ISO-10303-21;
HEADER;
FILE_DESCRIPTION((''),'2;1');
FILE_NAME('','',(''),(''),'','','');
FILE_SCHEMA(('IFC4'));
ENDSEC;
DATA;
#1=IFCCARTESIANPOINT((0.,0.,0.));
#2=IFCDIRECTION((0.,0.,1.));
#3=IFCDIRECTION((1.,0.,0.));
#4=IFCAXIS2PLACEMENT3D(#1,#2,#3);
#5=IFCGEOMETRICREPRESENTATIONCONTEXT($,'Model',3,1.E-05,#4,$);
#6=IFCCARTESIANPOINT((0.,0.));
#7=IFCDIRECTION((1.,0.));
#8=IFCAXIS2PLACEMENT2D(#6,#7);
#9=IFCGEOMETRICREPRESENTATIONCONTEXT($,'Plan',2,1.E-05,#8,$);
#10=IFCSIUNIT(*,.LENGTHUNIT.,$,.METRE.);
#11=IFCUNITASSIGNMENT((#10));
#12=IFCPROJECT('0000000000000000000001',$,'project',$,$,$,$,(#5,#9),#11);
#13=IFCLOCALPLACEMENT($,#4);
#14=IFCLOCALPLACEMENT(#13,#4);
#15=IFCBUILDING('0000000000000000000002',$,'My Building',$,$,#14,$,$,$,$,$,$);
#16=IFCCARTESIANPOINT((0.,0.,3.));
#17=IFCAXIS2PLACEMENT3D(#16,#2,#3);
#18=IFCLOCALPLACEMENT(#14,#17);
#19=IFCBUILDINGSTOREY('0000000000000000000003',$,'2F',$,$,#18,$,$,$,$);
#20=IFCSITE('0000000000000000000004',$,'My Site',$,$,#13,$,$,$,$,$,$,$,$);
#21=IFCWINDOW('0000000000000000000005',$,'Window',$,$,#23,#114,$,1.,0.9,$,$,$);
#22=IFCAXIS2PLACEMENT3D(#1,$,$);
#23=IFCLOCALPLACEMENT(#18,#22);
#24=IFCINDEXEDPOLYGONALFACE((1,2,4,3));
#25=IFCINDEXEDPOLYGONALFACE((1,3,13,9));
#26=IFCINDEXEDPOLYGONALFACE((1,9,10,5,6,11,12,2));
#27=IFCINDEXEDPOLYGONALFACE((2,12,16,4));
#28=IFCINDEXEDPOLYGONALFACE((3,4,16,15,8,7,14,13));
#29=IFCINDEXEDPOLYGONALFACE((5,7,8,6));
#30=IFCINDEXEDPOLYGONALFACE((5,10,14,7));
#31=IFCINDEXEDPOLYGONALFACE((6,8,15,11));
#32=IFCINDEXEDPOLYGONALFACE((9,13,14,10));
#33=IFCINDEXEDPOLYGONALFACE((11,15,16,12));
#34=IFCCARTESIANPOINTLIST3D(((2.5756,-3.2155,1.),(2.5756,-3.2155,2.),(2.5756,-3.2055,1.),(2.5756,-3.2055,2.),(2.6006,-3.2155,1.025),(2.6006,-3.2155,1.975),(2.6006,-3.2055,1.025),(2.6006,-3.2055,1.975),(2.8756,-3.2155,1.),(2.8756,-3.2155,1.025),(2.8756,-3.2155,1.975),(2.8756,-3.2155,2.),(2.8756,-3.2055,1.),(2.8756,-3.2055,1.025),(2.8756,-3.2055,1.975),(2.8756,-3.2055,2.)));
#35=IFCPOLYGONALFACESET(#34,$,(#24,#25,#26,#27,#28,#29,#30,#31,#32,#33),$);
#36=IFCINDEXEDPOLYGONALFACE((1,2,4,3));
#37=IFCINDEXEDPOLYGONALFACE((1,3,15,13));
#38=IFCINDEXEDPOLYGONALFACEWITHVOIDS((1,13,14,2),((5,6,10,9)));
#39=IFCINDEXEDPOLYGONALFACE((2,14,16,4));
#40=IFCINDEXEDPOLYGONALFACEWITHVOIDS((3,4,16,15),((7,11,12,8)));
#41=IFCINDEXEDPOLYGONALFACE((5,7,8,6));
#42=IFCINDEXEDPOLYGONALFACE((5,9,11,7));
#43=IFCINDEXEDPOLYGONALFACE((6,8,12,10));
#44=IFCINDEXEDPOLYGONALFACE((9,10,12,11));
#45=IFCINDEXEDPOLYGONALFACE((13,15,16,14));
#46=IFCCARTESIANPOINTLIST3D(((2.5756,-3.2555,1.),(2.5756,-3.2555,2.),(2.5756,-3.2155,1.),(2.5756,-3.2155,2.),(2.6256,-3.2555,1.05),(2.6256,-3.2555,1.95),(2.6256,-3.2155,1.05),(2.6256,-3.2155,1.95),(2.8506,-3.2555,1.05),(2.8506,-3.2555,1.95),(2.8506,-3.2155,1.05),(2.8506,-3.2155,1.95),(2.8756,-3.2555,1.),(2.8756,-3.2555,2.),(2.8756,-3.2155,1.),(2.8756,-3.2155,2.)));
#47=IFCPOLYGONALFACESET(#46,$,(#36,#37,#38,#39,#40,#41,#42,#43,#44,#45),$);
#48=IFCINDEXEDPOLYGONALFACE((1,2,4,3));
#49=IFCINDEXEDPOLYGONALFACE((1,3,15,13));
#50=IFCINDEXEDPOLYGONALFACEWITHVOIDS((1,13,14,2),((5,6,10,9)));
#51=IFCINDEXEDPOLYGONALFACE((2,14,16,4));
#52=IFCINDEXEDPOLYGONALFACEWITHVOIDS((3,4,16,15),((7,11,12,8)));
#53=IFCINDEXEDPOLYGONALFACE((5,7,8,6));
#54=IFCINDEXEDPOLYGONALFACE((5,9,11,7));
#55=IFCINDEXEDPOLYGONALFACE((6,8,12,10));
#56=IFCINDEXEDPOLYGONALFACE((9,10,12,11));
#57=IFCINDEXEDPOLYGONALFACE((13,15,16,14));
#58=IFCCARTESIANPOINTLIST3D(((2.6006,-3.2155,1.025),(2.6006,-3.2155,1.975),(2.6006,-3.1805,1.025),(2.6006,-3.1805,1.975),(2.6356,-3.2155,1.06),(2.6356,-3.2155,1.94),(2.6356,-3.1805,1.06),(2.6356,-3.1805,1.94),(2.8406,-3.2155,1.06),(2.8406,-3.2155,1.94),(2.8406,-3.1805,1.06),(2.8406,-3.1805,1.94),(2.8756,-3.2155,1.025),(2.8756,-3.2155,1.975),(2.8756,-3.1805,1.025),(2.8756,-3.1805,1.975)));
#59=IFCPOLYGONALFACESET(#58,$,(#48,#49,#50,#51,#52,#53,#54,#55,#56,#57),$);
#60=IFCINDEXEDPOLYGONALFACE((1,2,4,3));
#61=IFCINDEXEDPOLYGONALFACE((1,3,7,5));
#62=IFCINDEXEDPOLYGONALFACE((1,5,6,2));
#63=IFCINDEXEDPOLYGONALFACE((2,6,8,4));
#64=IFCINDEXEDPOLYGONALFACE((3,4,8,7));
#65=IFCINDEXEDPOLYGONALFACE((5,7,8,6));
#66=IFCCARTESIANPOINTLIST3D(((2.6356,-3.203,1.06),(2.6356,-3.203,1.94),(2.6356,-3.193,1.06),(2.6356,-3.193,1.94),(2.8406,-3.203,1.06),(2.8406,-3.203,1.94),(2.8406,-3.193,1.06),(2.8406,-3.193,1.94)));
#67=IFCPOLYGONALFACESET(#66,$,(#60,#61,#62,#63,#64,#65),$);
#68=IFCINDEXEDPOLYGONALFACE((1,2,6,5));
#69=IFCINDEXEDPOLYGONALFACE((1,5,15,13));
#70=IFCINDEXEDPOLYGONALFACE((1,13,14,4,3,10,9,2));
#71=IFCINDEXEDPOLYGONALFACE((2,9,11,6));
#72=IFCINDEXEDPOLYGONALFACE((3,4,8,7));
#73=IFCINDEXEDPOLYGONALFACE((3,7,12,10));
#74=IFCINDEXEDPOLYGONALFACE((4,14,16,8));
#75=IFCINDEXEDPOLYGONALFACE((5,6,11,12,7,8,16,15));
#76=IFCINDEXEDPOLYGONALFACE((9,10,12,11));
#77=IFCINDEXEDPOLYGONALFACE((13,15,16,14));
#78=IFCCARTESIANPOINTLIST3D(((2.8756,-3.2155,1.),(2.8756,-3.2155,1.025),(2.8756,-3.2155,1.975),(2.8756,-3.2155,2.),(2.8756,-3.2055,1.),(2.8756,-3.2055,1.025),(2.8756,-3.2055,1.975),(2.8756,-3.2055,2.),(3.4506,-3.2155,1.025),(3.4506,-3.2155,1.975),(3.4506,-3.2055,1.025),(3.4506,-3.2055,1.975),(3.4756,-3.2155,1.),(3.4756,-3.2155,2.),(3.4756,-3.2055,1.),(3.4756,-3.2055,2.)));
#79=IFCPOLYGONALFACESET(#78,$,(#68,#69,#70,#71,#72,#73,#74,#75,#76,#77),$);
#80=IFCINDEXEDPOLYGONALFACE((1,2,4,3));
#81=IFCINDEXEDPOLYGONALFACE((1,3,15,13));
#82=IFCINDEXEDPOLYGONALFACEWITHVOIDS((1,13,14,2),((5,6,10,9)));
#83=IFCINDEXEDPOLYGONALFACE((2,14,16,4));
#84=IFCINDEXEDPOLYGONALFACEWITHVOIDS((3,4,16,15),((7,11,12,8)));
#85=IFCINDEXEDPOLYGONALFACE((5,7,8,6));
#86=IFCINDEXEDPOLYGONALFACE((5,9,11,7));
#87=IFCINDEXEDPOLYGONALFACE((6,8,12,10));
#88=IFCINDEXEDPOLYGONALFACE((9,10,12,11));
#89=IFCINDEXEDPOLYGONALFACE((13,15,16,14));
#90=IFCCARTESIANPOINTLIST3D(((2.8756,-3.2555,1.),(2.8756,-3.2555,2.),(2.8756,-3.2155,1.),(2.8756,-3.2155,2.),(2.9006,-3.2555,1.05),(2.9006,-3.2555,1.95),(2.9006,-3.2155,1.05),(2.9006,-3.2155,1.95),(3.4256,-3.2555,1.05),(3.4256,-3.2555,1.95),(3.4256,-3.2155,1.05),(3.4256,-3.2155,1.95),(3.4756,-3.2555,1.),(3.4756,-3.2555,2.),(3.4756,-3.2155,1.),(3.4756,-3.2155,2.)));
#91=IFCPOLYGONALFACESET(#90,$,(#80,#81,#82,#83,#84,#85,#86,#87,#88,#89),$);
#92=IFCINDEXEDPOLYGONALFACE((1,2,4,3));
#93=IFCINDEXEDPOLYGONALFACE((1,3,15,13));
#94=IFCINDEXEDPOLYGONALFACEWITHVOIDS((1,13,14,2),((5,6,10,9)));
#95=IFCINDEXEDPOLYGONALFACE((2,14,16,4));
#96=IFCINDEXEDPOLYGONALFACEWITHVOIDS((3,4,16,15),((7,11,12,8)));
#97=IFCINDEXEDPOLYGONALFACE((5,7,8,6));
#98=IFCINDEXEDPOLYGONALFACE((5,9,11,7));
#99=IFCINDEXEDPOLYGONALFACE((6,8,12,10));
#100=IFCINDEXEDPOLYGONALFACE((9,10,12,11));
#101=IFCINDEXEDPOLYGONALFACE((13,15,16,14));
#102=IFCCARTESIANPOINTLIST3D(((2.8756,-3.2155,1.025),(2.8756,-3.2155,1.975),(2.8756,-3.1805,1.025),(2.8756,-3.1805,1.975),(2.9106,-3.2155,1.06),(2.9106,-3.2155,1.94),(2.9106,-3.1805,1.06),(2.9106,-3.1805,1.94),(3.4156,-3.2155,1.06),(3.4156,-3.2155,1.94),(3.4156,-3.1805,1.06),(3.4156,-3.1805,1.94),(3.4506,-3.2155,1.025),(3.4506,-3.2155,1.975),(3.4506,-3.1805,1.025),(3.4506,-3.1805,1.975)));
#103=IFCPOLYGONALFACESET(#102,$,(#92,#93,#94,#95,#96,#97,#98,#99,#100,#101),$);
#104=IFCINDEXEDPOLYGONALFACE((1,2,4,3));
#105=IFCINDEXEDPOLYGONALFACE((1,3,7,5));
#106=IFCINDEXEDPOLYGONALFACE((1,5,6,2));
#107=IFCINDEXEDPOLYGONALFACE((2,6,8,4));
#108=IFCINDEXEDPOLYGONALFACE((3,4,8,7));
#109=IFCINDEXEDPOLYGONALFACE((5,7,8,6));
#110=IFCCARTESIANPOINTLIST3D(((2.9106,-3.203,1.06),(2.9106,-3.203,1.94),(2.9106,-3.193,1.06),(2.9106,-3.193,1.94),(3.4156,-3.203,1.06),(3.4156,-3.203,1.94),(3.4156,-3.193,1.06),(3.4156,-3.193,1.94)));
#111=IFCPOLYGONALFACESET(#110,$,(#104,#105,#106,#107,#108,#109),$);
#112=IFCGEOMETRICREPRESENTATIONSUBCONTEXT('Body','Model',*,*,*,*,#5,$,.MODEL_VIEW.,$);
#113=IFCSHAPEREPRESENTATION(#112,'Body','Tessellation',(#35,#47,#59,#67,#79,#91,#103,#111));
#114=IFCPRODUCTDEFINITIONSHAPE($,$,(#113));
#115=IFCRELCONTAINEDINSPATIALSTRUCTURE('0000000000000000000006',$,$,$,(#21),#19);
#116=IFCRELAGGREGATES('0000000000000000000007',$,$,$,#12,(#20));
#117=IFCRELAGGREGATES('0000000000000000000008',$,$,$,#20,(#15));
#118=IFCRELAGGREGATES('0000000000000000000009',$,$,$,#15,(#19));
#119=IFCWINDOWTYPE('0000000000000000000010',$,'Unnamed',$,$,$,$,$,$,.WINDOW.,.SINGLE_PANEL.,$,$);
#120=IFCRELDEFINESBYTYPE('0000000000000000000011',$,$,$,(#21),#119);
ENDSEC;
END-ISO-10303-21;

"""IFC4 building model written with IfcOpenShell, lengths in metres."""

from ifc_helpers import new_model, entity, si_unit, frame, origin_with_axes, origin_2d_with_axis, place, context, subcontext, project, spatial, line, indexed_curve, outline, extrude, shape, source, transform, mapped, type_object, type_shapes, element, save


model = new_model("IFC4")

# Units and contexts
model_context = context("Model", 3, precision=1e-05, world=origin_with_axes())
plan_context = context("Plan", 2, precision=1e-05, world=origin_2d_with_axis())
body_context_1 = subcontext(model_context, "Body", "Model", "MODEL_VIEW")
body_context_2 = subcontext(plan_context, "Body", "Plan", "PLAN_VIEW")
ifc_project = project(units=[si_unit("LENGTHUNIT", "METRE")], contexts=[model_context, plan_context])

# Site, building, storey
site_placement = place(None, origin_with_axes())
site = spatial("IfcSite", under=ifc_project, at=site_placement, Name="My Site")
building_placement = place(site_placement, origin_with_axes())
building = spatial("IfcBuilding", under=site, at=building_placement, Name="My Building")
storey_placement = place(building_placement, frame((0.0, 0.0, 3.0), z_axis=(0.0, 0.0, 1.0), x_axis=(1.0, 0.0, 0.0)))
storey = spatial("IfcBuildingStorey", under=building, at=storey_placement, Name="2F")

# Window
window_type = type_object("IfcWindowType", Name="Unnamed", PartitioningType="SINGLE_PANEL", PredefinedType="WINDOW")
shared_shape_1 = source(origin_with_axes(), body_context_1, "Body", "SweptSolid", [
    extrude(outline(indexed_curve([(0.3, 0.0), (0.0, 0.0), (0.0, 1.0), (0.3, 1.0), (0.3, 0.975), (0.025, 0.975), (0.025, 0.025), (0.3, 0.025)], segments=[line(1, 2, 3, 4, 5, 6, 7, 8, 1)])), frame((0.0, 0.09, 0.0), z_axis=(0.0, -1.0, 0.0), x_axis=(1.0, 0.0, 0.0)), (0.0, 0.0, -1.0), 0.01),
    extrude(outline(indexed_curve([(0.0, 0.0), (0.3, 0.0), (0.3, 1.0), (0.0, 1.0)], segments=[line(1, 2, 3, 4, 1)]), holes=[indexed_curve([(0.05, 0.05), (0.275, 0.05), (0.275, 0.95), (0.05, 0.95)], segments=[line(1, 2, 3, 4, 1)])]), frame((0.0, 0.05, 0.0), z_axis=(0.0, -1.0, 0.0), x_axis=(1.0, 0.0, 0.0)), (0.0, 0.0, -1.0), 0.04),
    extrude(outline(indexed_curve([(0.0, 0.0), (0.275, 0.0), (0.275, 0.95), (0.0, 0.95)], segments=[line(1, 2, 3, 4, 1)]), holes=[indexed_curve([(0.035, 0.035), (0.24, 0.035), (0.24, 0.915), (0.035, 0.915)], segments=[line(1, 2, 3, 4, 1)])]), frame((0.025, 0.09, 0.025), z_axis=(0.0, -1.0, 0.0), x_axis=(1.0, 0.0, 0.0)), (0.0, 0.0, -1.0), 0.035),
    extrude(outline(indexed_curve([(0.035, 0.035), (0.24, 0.035), (0.24, 0.915), (0.035, 0.915)], segments=[line(1, 2, 3, 4, 1)])), frame((0.025, 0.1025, 0.025), z_axis=(0.0, -1.0, 0.0), x_axis=(1.0, 0.0, 0.0)), (0.0, 0.0, -1.0), 0.01),
    extrude(outline(indexed_curve([(0.0, 1.0), (0.6, 1.0), (0.6, 0.0), (0.0, 0.0), (0.0, 0.025), (0.575, 0.025), (0.575, 0.975), (0.0, 0.975)], segments=[line(1, 2, 3, 4, 5, 6, 7, 8, 1)])), frame((0.3, 0.09, 0.0), z_axis=(0.0, -1.0, 0.0), x_axis=(1.0, 0.0, 0.0)), (0.0, 0.0, -1.0), 0.01),
    extrude(outline(indexed_curve([(0.0, 0.0), (0.6, 0.0), (0.6, 1.0), (0.0, 1.0)], segments=[line(1, 2, 3, 4, 1)]), holes=[indexed_curve([(0.025, 0.05), (0.55, 0.05), (0.55, 0.95), (0.025, 0.95)], segments=[line(1, 2, 3, 4, 1)])]), frame((0.3, 0.05, 0.0), z_axis=(0.0, -1.0, 0.0), x_axis=(1.0, 0.0, 0.0)), (0.0, 0.0, -1.0), 0.04),
    extrude(outline(indexed_curve([(0.0, 0.0), (0.575, 0.0), (0.575, 0.95), (0.0, 0.95)], segments=[line(1, 2, 3, 4, 1)]), holes=[indexed_curve([(0.035, 0.035), (0.54, 0.035), (0.54, 0.915), (0.035, 0.915)], segments=[line(1, 2, 3, 4, 1)])]), frame((0.3, 0.09, 0.025), z_axis=(0.0, -1.0, 0.0), x_axis=(1.0, 0.0, 0.0)), (0.0, 0.0, -1.0), 0.035),
    extrude(outline(indexed_curve([(0.035, 0.035), (0.54, 0.035), (0.54, 0.915), (0.035, 0.915)], segments=[line(1, 2, 3, 4, 1)])), frame((0.3, 0.1025, 0.025), z_axis=(0.0, -1.0, 0.0), x_axis=(1.0, 0.0, 0.0)), (0.0, 0.0, -1.0), 0.01),
])
shared_shape_2 = source(origin_with_axes(), body_context_2, "Body", "Curve2D", [
    entity("IfcIndexedPolyCurve", entity("IfcCartesianPointList2D", [[0.05, 0.05], [0.275, 0.05]])),
    entity("IfcIndexedPolyCurve", entity("IfcCartesianPointList2D", [[0.0, 0.1], [0.025, 0.1], [0.025, 0.09], [0.05, 0.09], [0.05, 0.05], [0.0, 0.05]]), [entity("IfcLineIndex", [1, 2, 3, 4, 5, 6, 1])]),
    entity("IfcIndexedPolyCurve", entity("IfcCartesianPointList2D", [[0.3, 0.1], [0.3, 0.1], [0.3, 0.09], [0.275, 0.09], [0.275, 0.05], [0.3, 0.05]])),
    entity("IfcIndexedPolyCurve", entity("IfcCartesianPointList2D", [[0.025, 0.09], [0.06, 0.09], [0.06, 0.125], [0.025, 0.125]]), [entity("IfcLineIndex", [1, 2, 3, 4, 1])]),
    entity("IfcIndexedPolyCurve", entity("IfcCartesianPointList2D", [[0.3, 0.09], [0.265, 0.09], [0.265, 0.125], [0.3, 0.125]]), [entity("IfcLineIndex", [1, 2, 3, 4, 1])]),
    entity("IfcIndexedPolyCurve", entity("IfcCartesianPointList2D", [[0.06, 0.09], [0.265, 0.09]])),
    entity("IfcIndexedPolyCurve", entity("IfcCartesianPointList2D", [[0.06, 0.125], [0.265, 0.125]])),
    entity("IfcIndexedPolyCurve", entity("IfcCartesianPointList2D", [[0.06, 0.1075], [0.265, 0.1075]])),
    entity("IfcIndexedPolyCurve", entity("IfcCartesianPointList2D", [[0.325, 0.05], [0.85, 0.05]])),
    entity("IfcIndexedPolyCurve", entity("IfcCartesianPointList2D", [[0.3, 0.1], [0.3, 0.1], [0.3, 0.09], [0.325, 0.09], [0.325, 0.05], [0.3, 0.05]])),
    entity("IfcIndexedPolyCurve", entity("IfcCartesianPointList2D", [[0.9, 0.1], [0.875, 0.1], [0.875, 0.09], [0.85, 0.09], [0.85, 0.05], [0.9, 0.05]]), [entity("IfcLineIndex", [1, 2, 3, 4, 5, 6, 1])]),
    entity("IfcIndexedPolyCurve", entity("IfcCartesianPointList2D", [[0.3, 0.09], [0.335, 0.09], [0.335, 0.125], [0.3, 0.125]]), [entity("IfcLineIndex", [1, 2, 3, 4, 1])]),
    entity("IfcIndexedPolyCurve", entity("IfcCartesianPointList2D", [[0.875, 0.09], [0.84, 0.09], [0.84, 0.125], [0.875, 0.125]]), [entity("IfcLineIndex", [1, 2, 3, 4, 1])]),
    entity("IfcIndexedPolyCurve", entity("IfcCartesianPointList2D", [[0.335, 0.09], [0.84, 0.09]])),
    entity("IfcIndexedPolyCurve", entity("IfcCartesianPointList2D", [[0.335, 0.125], [0.84, 0.125]])),
    entity("IfcIndexedPolyCurve", entity("IfcCartesianPointList2D", [[0.335, 0.1075], [0.84, 0.1075]])),
])
type_shapes(window_type, [shared_shape_1, shared_shape_2])
window_placement = place(storey_placement, frame((2.5756, -3.3055, 1.0), z_axis=(0.0, 0.0, 1.0), x_axis=(1.0, 0.0, 0.0)))
element("IfcWindow", 1, at=window_placement, inside=storey, type_object=window_type, Name="Window", OverallHeight=1.0, OverallWidth=0.9, shapes=[
    shape(body_context_1, "Body", "MappedRepresentation", [mapped(shared_shape_1, transform((0.0, 0.0, 0.0), x_axis=(1.0, 0.0, 0.0), y_axis=(0.0, 1.0, 0.0), z_axis=(0.0, 0.0, 1.0), scale=1.0))]),
    shape(body_context_2, "Body", "MappedRepresentation", [mapped(shared_shape_2, transform((0.0, 0.0, 0.0), x_axis=(1.0, 0.0, 0.0), y_axis=(0.0, 1.0, 0.0), z_axis=(0.0, 0.0, 1.0), scale=1.0))]),
])

save(model, "model.ifc")
